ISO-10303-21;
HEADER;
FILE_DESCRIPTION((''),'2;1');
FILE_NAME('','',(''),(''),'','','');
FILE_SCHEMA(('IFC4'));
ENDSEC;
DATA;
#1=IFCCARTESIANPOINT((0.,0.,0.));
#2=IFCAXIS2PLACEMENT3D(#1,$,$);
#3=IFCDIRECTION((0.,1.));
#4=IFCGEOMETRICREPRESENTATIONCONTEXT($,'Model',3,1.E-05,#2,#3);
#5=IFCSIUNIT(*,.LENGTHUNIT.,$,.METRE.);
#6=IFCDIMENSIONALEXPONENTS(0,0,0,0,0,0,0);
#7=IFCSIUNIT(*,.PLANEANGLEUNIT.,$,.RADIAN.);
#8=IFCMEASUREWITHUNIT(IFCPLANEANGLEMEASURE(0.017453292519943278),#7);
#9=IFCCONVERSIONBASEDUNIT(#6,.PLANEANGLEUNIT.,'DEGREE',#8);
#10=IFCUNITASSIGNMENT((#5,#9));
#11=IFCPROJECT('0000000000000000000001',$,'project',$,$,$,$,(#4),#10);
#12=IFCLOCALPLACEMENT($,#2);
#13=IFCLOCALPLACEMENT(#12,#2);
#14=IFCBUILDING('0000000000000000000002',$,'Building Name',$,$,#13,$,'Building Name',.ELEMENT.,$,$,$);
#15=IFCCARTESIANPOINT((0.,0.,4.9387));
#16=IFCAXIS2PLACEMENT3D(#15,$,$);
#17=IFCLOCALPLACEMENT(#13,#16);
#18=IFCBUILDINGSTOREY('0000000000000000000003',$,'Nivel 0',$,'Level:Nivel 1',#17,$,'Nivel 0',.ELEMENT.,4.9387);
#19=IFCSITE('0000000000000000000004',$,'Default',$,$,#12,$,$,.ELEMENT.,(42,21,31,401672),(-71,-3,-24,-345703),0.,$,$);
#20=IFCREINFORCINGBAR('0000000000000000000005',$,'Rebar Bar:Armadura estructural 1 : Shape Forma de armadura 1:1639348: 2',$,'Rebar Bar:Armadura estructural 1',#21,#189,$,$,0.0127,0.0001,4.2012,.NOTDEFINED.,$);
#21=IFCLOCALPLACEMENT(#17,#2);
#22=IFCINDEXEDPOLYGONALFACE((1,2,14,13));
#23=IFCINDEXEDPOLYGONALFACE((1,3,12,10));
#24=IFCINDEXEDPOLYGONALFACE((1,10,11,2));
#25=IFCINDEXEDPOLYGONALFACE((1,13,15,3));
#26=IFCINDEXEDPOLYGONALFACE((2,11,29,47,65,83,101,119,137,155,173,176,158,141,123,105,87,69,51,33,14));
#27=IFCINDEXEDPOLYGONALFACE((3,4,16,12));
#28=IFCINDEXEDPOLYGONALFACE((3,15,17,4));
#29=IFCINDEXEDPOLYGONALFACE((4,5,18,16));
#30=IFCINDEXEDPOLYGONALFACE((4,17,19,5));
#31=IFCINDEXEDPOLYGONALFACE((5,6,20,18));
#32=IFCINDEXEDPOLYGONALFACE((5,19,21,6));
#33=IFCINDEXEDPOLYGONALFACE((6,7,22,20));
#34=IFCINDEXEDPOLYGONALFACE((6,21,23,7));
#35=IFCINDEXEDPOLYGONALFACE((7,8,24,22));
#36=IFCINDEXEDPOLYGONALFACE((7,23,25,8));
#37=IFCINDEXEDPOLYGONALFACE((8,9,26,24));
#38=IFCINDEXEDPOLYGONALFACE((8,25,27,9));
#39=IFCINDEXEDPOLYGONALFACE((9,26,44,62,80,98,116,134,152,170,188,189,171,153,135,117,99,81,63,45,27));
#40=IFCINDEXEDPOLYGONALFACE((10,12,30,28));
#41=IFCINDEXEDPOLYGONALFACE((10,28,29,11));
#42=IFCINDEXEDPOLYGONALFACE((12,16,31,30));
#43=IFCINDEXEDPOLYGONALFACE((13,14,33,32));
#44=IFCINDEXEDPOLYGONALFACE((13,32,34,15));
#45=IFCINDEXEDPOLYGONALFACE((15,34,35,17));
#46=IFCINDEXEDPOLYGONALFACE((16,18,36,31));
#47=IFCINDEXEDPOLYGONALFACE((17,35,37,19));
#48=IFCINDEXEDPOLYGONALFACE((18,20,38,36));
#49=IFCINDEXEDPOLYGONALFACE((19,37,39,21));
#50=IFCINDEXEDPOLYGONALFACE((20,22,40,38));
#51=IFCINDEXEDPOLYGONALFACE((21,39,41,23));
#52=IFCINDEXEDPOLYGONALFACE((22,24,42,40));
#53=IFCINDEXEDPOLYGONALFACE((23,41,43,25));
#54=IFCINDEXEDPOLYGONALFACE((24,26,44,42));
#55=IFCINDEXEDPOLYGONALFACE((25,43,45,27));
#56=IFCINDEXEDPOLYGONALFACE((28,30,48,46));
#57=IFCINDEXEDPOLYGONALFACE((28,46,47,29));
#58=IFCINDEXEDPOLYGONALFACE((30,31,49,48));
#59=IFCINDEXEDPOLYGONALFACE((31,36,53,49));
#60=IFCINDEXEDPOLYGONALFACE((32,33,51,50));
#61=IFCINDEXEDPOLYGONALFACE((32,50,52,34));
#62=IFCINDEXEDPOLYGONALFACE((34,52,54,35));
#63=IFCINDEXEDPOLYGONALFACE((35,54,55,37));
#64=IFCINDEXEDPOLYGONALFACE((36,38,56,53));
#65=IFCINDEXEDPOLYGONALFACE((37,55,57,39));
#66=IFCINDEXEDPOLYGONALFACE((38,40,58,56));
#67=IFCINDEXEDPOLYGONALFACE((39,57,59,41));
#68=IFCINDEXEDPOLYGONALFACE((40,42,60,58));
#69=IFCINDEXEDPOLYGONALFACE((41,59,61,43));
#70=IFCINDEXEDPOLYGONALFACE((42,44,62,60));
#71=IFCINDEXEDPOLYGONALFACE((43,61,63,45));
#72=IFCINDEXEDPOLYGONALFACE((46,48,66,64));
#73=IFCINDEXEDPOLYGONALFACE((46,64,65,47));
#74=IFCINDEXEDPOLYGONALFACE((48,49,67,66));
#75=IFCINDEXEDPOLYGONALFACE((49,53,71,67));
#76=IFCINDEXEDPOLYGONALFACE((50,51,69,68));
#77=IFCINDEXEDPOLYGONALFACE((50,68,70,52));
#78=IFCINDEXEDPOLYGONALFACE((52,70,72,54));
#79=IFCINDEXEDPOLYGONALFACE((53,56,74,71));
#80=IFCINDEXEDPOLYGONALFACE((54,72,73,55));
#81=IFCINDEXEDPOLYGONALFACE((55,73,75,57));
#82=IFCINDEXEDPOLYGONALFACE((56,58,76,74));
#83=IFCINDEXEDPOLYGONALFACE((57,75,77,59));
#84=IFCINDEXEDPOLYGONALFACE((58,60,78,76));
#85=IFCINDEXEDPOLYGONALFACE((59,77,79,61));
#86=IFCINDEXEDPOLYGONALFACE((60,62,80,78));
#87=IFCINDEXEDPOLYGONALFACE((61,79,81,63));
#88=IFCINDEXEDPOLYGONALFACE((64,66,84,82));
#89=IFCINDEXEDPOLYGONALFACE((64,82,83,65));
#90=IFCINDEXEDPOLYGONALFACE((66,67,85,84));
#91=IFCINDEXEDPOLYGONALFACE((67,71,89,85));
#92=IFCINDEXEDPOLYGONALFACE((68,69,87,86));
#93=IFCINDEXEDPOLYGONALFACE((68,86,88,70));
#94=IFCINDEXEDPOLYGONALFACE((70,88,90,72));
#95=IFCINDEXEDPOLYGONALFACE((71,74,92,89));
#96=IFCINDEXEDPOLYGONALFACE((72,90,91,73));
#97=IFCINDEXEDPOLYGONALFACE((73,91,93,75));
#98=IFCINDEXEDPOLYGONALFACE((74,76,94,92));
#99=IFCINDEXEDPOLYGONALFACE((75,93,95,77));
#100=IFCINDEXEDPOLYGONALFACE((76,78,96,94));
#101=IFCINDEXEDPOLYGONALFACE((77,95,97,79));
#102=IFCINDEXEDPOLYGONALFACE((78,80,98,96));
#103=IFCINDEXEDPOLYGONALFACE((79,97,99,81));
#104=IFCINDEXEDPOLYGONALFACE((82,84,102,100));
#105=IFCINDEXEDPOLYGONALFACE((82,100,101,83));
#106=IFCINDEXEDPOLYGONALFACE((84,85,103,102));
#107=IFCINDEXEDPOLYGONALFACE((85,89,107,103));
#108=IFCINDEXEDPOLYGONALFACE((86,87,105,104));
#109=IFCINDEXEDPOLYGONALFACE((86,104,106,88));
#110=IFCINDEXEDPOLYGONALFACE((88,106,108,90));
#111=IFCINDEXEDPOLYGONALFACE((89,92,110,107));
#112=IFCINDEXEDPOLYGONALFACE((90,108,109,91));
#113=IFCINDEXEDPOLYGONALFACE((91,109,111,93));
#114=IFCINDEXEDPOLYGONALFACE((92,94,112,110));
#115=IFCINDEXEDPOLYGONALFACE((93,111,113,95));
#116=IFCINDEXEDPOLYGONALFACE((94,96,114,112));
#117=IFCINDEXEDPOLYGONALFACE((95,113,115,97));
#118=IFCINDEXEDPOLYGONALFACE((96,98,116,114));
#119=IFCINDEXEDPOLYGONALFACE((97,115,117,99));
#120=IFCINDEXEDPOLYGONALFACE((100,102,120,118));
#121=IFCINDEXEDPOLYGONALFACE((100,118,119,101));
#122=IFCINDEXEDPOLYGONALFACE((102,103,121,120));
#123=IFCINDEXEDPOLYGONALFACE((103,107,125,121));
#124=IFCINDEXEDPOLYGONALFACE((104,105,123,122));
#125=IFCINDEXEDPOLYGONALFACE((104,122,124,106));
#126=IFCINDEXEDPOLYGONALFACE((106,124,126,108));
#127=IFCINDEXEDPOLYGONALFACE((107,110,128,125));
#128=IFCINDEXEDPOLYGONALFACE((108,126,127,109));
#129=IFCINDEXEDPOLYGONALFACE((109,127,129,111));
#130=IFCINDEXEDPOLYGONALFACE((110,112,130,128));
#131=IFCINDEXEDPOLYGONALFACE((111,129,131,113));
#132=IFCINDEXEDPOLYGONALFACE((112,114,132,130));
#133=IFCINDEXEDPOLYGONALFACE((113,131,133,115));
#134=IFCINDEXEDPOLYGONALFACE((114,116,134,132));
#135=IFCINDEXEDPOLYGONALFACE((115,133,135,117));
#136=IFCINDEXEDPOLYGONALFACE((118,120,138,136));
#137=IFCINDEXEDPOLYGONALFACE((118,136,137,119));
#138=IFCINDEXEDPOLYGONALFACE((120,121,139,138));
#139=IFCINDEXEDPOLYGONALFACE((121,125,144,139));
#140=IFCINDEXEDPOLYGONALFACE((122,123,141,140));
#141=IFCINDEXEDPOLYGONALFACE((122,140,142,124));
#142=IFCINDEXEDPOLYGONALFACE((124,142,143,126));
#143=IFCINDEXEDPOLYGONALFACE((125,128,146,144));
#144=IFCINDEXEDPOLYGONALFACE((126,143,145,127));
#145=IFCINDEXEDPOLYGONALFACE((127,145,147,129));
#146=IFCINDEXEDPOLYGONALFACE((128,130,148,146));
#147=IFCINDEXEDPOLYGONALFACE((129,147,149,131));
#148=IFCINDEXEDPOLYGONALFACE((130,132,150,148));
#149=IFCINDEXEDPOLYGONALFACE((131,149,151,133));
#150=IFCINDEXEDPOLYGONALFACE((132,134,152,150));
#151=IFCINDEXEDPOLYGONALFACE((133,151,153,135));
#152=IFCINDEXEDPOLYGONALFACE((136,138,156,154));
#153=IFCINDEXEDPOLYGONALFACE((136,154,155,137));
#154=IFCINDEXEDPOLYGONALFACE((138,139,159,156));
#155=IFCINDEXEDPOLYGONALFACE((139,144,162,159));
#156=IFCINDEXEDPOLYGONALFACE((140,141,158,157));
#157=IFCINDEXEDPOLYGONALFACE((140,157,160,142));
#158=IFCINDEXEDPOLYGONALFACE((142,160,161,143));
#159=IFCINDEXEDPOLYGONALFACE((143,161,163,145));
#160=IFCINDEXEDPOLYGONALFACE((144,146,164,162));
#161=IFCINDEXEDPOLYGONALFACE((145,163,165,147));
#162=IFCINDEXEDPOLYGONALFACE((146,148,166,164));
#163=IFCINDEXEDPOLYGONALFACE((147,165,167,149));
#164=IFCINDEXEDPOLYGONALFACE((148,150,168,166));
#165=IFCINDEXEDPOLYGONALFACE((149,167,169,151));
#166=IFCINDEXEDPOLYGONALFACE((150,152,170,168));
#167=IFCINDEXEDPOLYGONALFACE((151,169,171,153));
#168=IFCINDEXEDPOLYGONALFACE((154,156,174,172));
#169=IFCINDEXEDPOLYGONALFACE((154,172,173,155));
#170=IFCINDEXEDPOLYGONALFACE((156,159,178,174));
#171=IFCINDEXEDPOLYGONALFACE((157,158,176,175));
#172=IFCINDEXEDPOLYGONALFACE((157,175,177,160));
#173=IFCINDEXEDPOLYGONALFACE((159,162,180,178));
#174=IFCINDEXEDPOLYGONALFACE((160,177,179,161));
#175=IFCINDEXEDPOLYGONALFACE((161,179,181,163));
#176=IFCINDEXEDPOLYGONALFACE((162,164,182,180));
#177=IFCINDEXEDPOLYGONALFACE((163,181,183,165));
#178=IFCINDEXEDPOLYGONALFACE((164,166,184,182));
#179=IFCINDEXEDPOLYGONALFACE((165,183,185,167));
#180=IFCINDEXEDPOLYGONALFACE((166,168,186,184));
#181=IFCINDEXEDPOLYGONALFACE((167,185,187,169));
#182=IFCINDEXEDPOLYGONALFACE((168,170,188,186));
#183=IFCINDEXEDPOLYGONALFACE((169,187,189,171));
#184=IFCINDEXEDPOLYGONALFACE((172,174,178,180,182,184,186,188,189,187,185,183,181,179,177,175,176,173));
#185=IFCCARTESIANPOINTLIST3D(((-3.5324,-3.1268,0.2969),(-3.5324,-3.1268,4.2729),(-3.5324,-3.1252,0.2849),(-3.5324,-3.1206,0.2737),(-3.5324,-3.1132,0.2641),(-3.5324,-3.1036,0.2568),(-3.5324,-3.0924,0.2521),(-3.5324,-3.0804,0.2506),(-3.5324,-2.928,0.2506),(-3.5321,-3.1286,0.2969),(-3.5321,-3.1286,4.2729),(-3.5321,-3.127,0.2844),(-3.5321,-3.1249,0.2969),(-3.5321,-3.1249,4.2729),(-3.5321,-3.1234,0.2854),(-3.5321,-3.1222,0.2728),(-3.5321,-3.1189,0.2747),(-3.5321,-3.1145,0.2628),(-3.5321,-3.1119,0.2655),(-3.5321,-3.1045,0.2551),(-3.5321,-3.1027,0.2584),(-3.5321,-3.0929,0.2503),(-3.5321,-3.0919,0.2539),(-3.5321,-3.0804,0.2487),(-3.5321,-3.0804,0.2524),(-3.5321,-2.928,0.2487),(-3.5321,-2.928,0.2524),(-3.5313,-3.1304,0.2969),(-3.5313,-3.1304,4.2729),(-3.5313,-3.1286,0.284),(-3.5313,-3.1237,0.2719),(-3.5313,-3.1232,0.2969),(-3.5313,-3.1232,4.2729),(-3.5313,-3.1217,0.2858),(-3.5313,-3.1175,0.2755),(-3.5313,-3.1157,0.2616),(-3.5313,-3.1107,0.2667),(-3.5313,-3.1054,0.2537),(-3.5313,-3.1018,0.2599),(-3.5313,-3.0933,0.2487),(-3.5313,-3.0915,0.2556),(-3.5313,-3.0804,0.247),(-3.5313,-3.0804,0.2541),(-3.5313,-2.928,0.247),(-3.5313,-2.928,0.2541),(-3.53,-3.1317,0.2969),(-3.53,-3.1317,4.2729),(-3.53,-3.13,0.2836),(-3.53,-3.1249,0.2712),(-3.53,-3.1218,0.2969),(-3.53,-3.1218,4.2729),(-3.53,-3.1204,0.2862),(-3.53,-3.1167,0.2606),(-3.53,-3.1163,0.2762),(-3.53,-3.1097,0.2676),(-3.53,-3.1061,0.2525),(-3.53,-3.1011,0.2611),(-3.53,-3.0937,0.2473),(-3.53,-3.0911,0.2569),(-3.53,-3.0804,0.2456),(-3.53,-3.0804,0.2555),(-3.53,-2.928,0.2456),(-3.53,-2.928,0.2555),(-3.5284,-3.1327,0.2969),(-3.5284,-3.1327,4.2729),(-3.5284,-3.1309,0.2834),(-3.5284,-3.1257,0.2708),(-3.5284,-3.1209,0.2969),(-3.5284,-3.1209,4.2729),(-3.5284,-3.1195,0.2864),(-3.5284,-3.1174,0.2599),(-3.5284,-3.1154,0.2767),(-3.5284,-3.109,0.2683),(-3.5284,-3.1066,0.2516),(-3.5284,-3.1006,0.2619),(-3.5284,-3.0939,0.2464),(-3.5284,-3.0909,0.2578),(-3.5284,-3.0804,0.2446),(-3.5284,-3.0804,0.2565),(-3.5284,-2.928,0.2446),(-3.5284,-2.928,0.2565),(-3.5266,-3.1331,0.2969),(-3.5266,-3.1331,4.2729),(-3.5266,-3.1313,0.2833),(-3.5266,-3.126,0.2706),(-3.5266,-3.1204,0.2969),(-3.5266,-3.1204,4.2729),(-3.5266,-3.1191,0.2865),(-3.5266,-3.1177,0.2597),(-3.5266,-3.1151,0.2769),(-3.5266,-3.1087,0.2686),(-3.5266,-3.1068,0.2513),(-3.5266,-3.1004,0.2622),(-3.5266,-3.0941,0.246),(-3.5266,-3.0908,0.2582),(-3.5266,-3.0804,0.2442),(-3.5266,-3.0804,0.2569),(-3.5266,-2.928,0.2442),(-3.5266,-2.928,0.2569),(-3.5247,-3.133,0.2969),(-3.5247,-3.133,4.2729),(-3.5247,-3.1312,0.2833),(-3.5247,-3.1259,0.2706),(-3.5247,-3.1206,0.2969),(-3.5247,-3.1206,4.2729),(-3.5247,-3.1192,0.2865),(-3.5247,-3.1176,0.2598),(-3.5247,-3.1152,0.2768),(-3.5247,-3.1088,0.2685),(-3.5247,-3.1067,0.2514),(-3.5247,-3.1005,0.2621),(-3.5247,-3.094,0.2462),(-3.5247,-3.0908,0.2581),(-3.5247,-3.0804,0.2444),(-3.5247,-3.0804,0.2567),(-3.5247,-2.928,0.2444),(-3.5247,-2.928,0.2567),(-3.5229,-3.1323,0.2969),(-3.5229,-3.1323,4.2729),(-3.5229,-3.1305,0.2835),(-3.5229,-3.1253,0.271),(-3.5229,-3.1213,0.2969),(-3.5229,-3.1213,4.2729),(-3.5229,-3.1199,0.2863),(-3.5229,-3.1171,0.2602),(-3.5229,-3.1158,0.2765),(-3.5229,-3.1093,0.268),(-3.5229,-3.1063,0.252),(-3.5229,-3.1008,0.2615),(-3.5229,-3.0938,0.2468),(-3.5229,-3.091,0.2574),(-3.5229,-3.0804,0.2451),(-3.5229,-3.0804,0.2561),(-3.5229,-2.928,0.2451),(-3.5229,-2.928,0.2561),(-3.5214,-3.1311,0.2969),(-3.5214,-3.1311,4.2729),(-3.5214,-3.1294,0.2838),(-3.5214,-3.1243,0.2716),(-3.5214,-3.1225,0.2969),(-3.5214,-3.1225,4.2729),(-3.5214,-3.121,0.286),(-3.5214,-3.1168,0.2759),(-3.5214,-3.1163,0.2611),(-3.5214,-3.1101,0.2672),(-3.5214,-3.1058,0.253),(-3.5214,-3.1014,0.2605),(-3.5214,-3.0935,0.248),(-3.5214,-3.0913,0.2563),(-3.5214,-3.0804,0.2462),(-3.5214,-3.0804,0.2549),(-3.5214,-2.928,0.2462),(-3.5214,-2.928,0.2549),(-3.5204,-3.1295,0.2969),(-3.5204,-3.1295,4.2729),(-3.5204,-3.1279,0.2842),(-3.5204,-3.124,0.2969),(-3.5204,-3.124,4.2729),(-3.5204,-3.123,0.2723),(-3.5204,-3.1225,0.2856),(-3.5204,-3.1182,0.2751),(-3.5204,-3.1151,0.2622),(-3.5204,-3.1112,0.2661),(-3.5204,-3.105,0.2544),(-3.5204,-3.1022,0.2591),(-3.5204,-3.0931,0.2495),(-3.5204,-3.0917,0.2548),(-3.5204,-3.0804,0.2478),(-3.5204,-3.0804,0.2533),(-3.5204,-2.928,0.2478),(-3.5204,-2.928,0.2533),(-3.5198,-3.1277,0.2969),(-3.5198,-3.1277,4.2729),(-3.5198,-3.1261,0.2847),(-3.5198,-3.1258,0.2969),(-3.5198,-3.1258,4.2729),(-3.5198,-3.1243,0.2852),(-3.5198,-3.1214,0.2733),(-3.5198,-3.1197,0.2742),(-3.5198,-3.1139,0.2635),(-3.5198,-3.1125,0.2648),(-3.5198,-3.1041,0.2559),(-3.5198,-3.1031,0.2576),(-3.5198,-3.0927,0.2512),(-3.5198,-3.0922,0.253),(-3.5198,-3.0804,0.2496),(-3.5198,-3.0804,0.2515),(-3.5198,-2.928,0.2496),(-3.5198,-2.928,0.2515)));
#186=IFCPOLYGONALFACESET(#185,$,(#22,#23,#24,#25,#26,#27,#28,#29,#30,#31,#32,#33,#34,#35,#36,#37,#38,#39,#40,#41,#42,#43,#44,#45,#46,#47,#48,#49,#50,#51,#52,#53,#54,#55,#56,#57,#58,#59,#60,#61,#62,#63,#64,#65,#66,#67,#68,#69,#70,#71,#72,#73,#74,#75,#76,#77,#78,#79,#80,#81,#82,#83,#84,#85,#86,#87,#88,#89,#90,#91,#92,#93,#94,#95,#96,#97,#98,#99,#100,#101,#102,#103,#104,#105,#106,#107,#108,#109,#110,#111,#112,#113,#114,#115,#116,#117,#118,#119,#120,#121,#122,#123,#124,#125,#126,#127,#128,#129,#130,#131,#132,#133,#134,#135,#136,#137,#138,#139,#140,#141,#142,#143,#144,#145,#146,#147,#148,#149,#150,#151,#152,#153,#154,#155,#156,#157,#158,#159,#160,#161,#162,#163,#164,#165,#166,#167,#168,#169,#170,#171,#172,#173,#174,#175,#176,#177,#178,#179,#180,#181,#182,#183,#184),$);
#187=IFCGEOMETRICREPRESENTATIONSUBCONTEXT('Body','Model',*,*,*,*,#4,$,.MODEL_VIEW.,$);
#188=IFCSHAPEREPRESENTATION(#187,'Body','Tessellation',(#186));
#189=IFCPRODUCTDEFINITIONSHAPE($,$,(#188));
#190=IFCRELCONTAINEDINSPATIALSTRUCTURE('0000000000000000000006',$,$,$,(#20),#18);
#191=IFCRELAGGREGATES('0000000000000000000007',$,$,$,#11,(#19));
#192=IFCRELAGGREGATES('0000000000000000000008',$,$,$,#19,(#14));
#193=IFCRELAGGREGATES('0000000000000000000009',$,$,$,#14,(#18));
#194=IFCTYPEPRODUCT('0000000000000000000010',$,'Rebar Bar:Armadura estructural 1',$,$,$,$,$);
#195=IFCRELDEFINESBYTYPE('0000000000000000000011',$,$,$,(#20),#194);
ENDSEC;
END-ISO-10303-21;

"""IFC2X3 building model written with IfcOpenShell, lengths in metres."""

from ifc_helpers import new_model, entity, si_unit, converted_unit, direction, frame, origin, place, context, subcontext, project, spatial, type_object, element, save


model = new_model("IFC2X3")

# Units and contexts
model_context = context("Model", 3, precision=1e-05, world=origin(), true_north=direction((0.0, 1.0)))
body_context = subcontext(model_context, "Body", "Model", "MODEL_VIEW")
ifc_project = project(units=[si_unit("LENGTHUNIT", "METRE"), converted_unit("PLANEANGLEUNIT", "DEGREE", entity("IfcPlaneAngleMeasure", 0.017453292519943278), si_unit("PLANEANGLEUNIT", "RADIAN"), dimensions=[0, 0, 0, 0, 0, 0, 0])], contexts=[model_context])

# Site, building, storey
site_placement = place(None, origin())
site = spatial("IfcSite", under=ifc_project, at=site_placement, Name="Default", CompositionType="ELEMENT", RefLatitude=(42, 21, 31, 401672), RefLongitude=(-71, -3, -24, -345703), RefElevation=0.0)
building_placement = place(site_placement, origin())
building = spatial("IfcBuilding", under=site, at=building_placement, Name="Building Name", LongName="Building Name", CompositionType="ELEMENT")
storey_placement = place(building_placement, frame((0.0, 0.0, 4.9387)))
storey = spatial("IfcBuildingStorey", under=building, at=storey_placement, Name="Nivel 0", ObjectType="Level:Nivel 1", LongName="Nivel 0", CompositionType="ELEMENT", Elevation=4.9387)

# Reinforcing bar
type_product = type_object("IfcTypeProduct", Name="Rebar Bar:Armadura estructural 1")
reinforcing_bar_1_placement = place(storey_placement, origin())
element("IfcReinforcingBar", 1, at=reinforcing_bar_1_placement, inside=storey, type_object=type_product, Name="Rebar Bar:Armadura estructural 1 : Shape Forma de armadura 1:1639348: 2", ObjectType="Rebar Bar:Armadura estructural 1", BarLength=4.2012, BarRole="NOTDEFINED", CrossSectionArea=0.0001, NominalDiameter=0.0127, context=body_context, shape_type="AdvancedSweptSolid", body=[
    entity("IfcSweptDiskSolid", entity("IfcCompositeCurve", [entity("IfcCompositeCurveSegment", "CONTINUOUS", True, entity("IfcPolyline", [entity("IfcCartesianPoint", [-3.5261, -2.928, 0.2506]), entity("IfcCartesianPoint", [-3.5261, -3.0804, 0.2506])])), entity("IfcCompositeCurveSegment", "CONTINUOUS", True, entity("IfcTrimmedCurve", entity("IfcCircle", entity("IfcAxis2Placement3D", entity("IfcCartesianPoint", [-3.5261, -3.0804, 0.2969]), entity("IfcDirection", [-1.0, 0.0, 0.0]), entity("IfcDirection", [0.0, -1.0, 0.0])), 0.0464), [entity("IfcParameterValue", 270.0)], [entity("IfcParameterValue", 360.0)], True, "PARAMETER")), entity("IfcCompositeCurveSegment", "CONTINUOUS", True, entity("IfcPolyline", [entity("IfcCartesianPoint", [-3.5261, -3.1268, 0.2969]), entity("IfcCartesianPoint", [-3.5261, -3.1268, 4.2729])]))], False), 0.0063, None, 0.0, 92.0),
])

save(model, "model.ifc")
